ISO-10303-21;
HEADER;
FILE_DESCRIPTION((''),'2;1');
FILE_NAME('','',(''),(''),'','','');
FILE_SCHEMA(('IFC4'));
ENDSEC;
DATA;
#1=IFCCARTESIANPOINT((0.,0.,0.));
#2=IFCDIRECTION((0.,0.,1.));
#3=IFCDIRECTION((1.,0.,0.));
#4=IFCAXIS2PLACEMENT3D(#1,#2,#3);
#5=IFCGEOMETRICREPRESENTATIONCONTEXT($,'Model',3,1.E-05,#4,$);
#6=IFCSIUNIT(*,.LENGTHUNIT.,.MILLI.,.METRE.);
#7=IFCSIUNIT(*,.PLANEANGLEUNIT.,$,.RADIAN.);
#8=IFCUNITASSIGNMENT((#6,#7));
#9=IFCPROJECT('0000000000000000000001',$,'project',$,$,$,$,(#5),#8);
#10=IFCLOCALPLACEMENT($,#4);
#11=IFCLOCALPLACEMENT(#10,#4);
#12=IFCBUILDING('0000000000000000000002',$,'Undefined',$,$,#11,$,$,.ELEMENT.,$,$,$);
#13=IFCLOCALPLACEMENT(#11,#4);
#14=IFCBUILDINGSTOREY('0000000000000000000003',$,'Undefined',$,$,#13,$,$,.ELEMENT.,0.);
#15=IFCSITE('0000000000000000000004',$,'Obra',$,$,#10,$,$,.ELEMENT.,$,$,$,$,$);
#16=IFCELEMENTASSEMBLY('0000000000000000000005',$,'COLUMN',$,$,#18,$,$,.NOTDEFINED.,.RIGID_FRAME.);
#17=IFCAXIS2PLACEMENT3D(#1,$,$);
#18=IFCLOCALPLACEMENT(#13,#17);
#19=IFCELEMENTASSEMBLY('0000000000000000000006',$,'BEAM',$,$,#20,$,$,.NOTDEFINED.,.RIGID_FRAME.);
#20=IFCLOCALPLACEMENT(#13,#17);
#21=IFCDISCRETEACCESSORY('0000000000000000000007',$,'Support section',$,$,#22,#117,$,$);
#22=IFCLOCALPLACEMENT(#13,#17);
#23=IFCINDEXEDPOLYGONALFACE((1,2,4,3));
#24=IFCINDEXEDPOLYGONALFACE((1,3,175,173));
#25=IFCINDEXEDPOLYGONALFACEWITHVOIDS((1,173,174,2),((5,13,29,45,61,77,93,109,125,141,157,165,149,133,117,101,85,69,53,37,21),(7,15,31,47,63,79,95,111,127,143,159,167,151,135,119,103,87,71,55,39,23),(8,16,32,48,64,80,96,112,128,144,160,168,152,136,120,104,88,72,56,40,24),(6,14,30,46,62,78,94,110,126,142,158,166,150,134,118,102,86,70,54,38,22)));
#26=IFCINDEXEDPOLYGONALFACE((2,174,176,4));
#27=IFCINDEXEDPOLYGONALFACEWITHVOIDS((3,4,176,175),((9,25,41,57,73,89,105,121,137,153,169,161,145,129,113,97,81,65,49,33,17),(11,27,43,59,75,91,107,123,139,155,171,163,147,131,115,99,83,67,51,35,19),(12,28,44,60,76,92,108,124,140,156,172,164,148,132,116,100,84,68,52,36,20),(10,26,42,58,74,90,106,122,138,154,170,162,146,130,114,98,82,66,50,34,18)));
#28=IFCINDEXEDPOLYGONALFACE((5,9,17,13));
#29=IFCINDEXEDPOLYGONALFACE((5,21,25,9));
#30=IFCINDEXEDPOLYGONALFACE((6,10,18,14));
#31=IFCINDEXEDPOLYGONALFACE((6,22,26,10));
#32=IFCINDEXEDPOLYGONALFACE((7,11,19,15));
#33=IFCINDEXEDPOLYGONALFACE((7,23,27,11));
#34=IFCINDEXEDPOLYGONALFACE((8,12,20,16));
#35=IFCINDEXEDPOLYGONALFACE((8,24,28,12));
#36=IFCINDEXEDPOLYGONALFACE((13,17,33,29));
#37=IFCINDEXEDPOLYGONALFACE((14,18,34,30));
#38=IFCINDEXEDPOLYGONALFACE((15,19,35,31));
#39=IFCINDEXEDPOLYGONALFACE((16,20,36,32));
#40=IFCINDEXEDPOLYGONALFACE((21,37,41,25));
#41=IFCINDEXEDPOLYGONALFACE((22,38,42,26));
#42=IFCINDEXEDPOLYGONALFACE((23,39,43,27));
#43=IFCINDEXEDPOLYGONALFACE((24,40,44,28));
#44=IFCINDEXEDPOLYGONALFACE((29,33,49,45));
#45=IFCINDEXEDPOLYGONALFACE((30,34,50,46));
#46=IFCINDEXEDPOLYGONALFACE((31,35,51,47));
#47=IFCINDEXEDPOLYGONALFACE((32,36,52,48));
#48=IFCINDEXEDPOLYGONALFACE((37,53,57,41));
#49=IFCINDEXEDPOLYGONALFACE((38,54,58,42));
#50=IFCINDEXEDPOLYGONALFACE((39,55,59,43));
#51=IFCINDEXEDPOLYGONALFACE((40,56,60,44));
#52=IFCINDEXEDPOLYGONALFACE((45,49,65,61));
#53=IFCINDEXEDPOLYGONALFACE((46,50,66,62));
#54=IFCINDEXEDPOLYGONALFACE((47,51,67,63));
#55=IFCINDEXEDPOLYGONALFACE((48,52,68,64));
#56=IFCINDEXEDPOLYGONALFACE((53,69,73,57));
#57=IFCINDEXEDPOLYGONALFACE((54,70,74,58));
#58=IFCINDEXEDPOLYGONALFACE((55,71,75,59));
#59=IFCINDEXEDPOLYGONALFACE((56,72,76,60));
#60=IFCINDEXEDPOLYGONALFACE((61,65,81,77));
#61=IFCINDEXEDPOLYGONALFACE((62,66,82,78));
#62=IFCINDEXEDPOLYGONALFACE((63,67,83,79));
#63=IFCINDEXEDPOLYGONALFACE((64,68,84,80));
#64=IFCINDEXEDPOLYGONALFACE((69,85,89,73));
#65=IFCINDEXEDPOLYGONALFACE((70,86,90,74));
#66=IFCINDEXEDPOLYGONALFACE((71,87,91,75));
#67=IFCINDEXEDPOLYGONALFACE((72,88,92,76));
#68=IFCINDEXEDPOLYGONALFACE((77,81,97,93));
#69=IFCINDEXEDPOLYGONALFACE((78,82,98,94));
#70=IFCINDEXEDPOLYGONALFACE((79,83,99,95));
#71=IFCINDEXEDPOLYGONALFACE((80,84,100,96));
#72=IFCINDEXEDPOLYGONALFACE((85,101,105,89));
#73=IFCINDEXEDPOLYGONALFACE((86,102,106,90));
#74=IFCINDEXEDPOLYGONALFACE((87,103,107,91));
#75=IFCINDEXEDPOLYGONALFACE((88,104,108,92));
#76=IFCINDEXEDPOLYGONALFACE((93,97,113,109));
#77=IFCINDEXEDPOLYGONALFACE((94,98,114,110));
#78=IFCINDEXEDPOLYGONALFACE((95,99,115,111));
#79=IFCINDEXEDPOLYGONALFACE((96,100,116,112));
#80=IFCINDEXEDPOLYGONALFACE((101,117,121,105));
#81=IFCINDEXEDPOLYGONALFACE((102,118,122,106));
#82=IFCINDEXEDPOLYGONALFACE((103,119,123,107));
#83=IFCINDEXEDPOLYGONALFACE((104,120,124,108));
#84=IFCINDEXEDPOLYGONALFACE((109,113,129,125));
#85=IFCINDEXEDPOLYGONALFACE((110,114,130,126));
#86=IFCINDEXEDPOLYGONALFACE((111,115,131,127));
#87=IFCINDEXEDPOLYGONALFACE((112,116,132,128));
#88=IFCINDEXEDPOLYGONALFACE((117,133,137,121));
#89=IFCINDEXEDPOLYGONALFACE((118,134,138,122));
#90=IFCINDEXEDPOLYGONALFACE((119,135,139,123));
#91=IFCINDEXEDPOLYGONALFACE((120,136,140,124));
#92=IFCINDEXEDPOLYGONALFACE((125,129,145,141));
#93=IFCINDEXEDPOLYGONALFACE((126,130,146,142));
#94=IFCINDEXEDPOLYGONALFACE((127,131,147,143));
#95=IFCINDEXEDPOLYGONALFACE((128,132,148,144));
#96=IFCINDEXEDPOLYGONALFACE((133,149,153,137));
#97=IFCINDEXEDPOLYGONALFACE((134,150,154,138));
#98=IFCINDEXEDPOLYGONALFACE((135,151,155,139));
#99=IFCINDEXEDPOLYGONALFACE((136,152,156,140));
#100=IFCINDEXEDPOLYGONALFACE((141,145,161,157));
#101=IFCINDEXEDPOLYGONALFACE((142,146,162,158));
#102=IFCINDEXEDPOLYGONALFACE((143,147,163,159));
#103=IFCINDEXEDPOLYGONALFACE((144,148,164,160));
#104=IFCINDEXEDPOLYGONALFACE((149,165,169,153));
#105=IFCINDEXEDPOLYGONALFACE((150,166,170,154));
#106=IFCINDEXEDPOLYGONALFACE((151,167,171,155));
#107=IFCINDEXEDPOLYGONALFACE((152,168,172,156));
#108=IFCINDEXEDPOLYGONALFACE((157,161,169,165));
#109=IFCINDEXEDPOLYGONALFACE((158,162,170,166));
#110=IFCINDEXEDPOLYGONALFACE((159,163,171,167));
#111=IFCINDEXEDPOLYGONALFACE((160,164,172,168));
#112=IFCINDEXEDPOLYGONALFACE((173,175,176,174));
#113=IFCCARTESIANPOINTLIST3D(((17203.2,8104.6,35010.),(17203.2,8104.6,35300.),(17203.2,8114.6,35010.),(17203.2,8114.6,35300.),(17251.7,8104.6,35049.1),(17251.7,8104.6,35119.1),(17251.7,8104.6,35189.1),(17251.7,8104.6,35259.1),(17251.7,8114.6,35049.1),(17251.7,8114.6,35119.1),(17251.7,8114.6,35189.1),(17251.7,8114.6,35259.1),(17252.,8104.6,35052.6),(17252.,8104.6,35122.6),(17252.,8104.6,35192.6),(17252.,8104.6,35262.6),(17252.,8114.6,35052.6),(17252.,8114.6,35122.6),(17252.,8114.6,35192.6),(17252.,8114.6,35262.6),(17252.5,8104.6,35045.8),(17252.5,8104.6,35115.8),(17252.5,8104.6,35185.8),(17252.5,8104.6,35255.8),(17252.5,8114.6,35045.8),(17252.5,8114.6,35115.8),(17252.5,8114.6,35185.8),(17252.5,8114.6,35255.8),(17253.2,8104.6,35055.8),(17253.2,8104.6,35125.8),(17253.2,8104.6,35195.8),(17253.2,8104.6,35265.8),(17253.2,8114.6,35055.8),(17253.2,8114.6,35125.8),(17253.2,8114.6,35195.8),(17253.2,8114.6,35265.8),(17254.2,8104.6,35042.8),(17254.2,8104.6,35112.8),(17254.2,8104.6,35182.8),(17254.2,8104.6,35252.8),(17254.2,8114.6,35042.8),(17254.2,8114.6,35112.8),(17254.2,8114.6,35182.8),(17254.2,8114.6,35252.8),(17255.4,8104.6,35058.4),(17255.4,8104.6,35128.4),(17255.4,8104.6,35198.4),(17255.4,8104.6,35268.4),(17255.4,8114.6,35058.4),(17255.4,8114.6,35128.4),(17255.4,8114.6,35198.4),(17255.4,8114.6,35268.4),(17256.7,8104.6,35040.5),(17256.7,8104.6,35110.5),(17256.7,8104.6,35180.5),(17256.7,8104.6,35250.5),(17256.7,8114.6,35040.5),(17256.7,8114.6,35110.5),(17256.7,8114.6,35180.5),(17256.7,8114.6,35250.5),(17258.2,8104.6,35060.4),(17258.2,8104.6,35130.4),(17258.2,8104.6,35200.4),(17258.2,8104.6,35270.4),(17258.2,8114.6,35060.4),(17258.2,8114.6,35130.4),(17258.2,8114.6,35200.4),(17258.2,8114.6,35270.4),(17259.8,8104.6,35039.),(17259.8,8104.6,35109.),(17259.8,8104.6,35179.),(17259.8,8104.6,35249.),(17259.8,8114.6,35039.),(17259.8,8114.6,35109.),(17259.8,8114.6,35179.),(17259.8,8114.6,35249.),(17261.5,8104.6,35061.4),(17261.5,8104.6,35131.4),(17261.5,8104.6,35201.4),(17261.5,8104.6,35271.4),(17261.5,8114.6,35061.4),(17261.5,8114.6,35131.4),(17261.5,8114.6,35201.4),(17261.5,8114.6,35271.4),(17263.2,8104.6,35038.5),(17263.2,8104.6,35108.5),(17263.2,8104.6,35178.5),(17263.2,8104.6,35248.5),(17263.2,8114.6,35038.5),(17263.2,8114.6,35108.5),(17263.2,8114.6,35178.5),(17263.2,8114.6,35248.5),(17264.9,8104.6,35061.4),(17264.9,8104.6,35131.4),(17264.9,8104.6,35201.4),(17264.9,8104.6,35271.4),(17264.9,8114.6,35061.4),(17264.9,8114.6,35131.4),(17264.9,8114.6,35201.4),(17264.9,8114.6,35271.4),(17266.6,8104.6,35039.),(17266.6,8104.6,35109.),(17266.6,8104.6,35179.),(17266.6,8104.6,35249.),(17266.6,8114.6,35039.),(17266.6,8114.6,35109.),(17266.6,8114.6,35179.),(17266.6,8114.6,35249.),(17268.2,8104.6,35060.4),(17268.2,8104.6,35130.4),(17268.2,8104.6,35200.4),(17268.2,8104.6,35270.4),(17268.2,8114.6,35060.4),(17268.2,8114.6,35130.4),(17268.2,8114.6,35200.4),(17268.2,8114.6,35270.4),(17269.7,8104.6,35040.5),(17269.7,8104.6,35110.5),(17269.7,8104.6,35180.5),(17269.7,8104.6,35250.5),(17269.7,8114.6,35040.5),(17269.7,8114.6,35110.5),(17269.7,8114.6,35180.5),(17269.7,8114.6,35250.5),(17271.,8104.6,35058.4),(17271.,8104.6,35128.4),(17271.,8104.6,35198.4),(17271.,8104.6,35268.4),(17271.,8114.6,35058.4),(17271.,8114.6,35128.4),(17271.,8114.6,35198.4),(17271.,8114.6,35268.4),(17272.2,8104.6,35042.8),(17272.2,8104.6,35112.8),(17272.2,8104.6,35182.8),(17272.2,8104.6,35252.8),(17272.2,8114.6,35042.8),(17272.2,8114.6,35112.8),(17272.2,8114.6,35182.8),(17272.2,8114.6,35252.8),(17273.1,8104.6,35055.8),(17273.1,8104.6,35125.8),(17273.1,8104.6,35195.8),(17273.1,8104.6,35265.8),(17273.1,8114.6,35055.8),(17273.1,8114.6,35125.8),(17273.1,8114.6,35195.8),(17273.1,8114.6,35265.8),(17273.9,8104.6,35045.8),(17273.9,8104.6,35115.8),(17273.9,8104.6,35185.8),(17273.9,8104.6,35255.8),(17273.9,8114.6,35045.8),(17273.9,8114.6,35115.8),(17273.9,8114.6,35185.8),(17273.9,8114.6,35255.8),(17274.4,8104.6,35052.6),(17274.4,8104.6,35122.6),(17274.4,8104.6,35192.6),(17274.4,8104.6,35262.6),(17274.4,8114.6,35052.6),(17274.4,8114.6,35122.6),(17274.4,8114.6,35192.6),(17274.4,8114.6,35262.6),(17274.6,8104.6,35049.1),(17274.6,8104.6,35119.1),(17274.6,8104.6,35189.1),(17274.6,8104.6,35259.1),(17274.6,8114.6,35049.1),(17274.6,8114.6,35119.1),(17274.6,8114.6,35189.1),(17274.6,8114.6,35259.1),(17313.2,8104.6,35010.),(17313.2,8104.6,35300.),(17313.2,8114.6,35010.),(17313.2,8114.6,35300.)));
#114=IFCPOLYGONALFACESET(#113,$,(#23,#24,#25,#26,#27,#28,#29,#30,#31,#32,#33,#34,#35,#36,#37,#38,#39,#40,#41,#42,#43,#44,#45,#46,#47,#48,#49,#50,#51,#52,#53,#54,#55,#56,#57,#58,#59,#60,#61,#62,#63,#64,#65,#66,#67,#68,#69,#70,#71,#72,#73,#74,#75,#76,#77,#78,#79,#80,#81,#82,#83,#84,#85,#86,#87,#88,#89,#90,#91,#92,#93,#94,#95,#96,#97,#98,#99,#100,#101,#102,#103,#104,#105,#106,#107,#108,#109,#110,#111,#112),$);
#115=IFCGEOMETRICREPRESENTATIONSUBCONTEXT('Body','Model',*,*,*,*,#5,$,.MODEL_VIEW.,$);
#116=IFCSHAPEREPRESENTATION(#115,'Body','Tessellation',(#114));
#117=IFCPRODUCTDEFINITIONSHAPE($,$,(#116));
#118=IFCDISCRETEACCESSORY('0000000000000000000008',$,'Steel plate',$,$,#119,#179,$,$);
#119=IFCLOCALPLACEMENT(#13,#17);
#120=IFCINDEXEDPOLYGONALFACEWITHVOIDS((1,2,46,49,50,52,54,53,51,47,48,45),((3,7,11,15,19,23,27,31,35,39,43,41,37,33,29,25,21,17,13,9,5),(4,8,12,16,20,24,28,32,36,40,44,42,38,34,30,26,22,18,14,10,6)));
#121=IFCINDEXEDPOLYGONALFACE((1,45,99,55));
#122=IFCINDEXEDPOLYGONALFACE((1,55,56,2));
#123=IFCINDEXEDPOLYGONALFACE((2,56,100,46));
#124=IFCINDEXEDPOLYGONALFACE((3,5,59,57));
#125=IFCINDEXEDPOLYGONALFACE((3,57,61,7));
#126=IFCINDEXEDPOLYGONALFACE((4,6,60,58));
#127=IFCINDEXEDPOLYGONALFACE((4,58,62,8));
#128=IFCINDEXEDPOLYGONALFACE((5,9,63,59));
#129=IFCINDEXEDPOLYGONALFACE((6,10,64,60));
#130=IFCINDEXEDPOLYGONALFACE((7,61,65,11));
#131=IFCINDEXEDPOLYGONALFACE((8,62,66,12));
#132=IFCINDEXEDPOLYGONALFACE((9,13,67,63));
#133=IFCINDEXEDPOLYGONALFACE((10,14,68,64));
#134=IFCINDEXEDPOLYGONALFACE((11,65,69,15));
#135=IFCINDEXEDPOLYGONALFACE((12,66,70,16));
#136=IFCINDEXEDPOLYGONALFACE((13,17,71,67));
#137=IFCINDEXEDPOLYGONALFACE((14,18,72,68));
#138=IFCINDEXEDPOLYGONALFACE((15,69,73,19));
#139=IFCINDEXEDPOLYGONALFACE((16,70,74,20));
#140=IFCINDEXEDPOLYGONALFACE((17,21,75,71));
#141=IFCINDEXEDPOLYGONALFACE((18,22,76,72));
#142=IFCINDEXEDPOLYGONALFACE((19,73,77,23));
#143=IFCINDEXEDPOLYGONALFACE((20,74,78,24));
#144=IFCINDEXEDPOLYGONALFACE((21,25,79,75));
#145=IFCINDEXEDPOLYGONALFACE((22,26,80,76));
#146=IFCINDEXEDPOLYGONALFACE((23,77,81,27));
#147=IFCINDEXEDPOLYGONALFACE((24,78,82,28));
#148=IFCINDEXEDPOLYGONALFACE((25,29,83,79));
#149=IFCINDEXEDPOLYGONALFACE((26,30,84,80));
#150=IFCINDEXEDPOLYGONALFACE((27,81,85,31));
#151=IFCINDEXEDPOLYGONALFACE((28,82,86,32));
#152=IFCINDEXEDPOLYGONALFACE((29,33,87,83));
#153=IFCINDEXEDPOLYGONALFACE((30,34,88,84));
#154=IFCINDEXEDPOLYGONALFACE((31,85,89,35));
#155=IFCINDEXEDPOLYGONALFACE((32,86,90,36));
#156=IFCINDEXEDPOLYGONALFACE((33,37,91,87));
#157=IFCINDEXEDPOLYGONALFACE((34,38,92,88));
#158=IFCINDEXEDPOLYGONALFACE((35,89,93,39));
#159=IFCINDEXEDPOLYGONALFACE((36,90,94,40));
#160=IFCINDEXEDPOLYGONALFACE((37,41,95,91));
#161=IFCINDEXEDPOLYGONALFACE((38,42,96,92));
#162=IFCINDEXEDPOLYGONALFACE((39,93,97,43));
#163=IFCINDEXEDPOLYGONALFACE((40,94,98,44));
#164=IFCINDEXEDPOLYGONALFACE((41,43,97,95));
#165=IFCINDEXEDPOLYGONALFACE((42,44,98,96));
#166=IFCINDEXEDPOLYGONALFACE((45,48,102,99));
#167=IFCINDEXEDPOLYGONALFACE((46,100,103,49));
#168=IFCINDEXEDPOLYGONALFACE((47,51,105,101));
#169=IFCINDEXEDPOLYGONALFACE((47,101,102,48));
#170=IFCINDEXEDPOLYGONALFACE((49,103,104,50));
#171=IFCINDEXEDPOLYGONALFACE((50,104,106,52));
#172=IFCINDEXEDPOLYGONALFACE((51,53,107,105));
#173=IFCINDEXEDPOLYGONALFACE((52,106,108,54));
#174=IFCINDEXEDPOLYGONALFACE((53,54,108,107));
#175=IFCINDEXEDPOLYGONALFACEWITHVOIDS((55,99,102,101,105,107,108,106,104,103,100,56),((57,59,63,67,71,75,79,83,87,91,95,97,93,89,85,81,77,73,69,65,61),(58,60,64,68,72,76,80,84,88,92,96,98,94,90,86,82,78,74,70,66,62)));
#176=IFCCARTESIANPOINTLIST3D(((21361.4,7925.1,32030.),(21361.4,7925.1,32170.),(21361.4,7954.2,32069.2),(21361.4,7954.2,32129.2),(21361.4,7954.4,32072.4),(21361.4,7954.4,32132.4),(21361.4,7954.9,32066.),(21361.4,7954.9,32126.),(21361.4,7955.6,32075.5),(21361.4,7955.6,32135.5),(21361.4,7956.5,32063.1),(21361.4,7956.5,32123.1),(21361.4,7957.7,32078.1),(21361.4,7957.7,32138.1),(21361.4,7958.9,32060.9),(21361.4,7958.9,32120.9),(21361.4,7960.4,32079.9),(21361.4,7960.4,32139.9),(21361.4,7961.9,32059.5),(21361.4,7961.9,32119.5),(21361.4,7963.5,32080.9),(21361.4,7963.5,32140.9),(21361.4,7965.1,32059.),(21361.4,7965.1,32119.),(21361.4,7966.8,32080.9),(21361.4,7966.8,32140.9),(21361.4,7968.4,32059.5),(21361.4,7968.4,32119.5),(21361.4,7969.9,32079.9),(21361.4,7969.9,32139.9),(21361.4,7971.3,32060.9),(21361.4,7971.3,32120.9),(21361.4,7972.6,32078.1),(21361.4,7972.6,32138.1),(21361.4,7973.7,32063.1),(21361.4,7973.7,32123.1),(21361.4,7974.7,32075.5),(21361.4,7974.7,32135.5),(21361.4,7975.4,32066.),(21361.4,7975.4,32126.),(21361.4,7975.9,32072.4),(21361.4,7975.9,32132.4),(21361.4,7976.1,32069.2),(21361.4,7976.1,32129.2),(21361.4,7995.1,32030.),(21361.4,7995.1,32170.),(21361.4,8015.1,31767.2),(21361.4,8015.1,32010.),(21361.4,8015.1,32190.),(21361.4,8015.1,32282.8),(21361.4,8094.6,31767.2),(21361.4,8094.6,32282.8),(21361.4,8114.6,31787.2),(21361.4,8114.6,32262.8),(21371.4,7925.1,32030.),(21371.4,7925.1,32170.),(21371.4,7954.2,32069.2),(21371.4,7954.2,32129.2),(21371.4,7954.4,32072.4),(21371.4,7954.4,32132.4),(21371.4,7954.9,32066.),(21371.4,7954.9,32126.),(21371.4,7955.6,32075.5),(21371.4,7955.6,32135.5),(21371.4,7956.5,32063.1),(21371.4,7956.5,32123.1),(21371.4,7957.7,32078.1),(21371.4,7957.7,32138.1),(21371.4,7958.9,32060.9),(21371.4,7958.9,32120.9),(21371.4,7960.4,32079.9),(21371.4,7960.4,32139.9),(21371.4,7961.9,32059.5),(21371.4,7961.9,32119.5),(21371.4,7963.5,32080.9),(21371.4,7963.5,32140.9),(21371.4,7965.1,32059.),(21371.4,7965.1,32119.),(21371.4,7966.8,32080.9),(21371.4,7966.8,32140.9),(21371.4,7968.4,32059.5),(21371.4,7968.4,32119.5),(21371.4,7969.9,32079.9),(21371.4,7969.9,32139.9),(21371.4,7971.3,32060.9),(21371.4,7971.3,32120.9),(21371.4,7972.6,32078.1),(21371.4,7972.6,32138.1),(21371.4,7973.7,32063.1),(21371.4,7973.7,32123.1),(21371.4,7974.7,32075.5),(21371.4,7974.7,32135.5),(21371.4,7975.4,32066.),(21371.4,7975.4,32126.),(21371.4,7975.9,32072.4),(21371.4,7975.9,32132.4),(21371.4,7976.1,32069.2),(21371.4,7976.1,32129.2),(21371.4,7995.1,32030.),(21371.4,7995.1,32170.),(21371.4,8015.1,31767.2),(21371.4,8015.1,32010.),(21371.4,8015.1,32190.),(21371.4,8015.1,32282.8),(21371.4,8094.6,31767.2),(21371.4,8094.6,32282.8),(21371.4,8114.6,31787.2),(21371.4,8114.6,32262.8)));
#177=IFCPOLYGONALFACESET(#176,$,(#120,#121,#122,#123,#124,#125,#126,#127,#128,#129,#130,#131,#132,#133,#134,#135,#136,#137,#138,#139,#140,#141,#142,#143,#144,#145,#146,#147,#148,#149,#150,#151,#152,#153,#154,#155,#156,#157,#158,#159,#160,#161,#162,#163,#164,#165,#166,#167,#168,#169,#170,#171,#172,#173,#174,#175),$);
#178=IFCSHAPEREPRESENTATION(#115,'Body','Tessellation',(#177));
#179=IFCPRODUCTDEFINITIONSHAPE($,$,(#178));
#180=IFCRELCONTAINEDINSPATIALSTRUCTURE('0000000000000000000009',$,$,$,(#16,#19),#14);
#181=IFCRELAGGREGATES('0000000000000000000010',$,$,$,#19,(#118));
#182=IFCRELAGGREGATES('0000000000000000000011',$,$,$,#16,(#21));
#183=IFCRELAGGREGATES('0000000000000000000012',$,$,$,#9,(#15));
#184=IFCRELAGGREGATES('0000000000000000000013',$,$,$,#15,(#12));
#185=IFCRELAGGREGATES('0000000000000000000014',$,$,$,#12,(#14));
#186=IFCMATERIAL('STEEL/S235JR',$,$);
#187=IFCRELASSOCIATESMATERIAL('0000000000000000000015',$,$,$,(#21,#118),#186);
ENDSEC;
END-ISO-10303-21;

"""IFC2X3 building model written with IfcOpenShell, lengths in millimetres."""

from ifc_helpers import new_model, si_unit, frame, origin_with_axes, origin_2d_with_axis, place, context, subcontext, project, spatial, polyline, rectangle, circle, outline, extrude, source, transform, mapped, material, element, aggregate, save


model = new_model("IFC2X3")

# Units and contexts
model_context = context("Model", 3, precision=1e-05, world=origin_with_axes())
body_context = subcontext(model_context, "Body", "Model", "MODEL_VIEW")
ifc_project = project(units=[si_unit("LENGTHUNIT", "METRE", prefix="MILLI"), si_unit("PLANEANGLEUNIT", "RADIAN")], contexts=[model_context])

# Site, building, storey
site_placement = place(None, origin_with_axes())
site = spatial("IfcSite", under=ifc_project, at=site_placement, Name="Obra", CompositionType="ELEMENT")
building_placement = place(site_placement, origin_with_axes())
building = spatial("IfcBuilding", under=site, at=building_placement, Name="Undefined", CompositionType="ELEMENT")
storey_placement = place(building_placement, origin_with_axes())
storey = spatial("IfcBuildingStorey", under=building, at=storey_placement, Name="Undefined", CompositionType="ELEMENT", Elevation=0.0)

# Element assembly
assembly_1_placement = place(storey_placement, origin_with_axes())
assembly_1 = element("IfcElementAssembly", 1, at=assembly_1_placement, inside=storey, Name="COLUMN", AssemblyPlace="NOTDEFINED", PredefinedType="RIGID_FRAME")
ifc_material_1 = material(Name="STEEL/S235JR")

# Element assembly
assembly_2_placement = place(storey_placement, origin_with_axes())
assembly_2 = element("IfcElementAssembly", 2, at=assembly_2_placement, inside=storey, Name="BEAM", AssemblyPlace="NOTDEFINED", PredefinedType="RIGID_FRAME")

# Discrete accessories, openings
discrete_accessory_1_placement = place(assembly_1_placement, frame((17258.2, 8109.6, 35010.0), z_axis=(0.0, 0.0, 1.0), x_axis=(-1.0, 0.0, 0.0)))
discrete_accessory_1 = element("IfcDiscreteAccessory", 3, at=discrete_accessory_1_placement, material=ifc_material_1, Name="Support section", context=body_context, shape_type="SweptSolid", body=[
    extrude(rectangle(XDim=10.0, YDim=110.0, at=origin_2d_with_axis()), frame((0.0, 0.0, 290.0), z_axis=(0.0, 0.0, -1.0), x_axis=(0.0, 1.0, 0.0)), (0.0, 0.0, 1.0), 290.0),
])
shared_shape_1 = source(origin_with_axes(), body_context, "Body", "SweptSolid", [
    extrude(circle(Radius=11.5, at=origin_2d_with_axis()), frame((0.0, -15.6, 0.0), z_axis=(0.0, 1.0, 0.0), x_axis=(1.0, 0.0, 0.0)), (0.0, 0.0, 1.0), 10.2),
])
opening_1_placement = place(assembly_1_placement, frame((17213.2, 8120.1, 35350.0), z_axis=(1.0, 0.0, 0.0), x_axis=(0.0, 0.0, -1.0)))
element("IfcOpeningElement", 4, at=opening_1_placement, cuts=discrete_accessory_1, ObjectType="Opening", context=body_context, shape_type="MappedRepresentation", body=[
    mapped(shared_shape_1, transform((90.0, 0.0, 50.0))),
    mapped(shared_shape_1, transform((160.0, 0.0, 50.0))),
    mapped(shared_shape_1, transform((230.0, 0.0, 50.0))),
    mapped(shared_shape_1, transform((300.0, 0.0, 50.0))),
])
discrete_accessory_2_placement = place(assembly_2_placement, frame((21366.4, 8114.6, 31787.2), z_axis=(-1.0, 0.0, 0.0), x_axis=(0.0, -0.707107, -0.707107)))
discrete_accessory_2 = element("IfcDiscreteAccessory", 5, at=discrete_accessory_2_placement, material=ifc_material_1, Name="Steel plate", context=body_context, shape_type="SweptSolid", body=[
    extrude(outline(polyline([(0.0, 0.0), (28.3, 0.0), (84.5, 56.2), (-87.2, 227.9), (-87.2, 256.1), (-37.7, 305.6), (-136.7, 404.6), (-186.2, 355.1), (-214.5, 355.1), (-280.1, 420.8), (-336.3, 364.6), (-336.3, 336.3), (0.0, 0.0)])), frame((0.0, 0.0, -5.0), z_axis=(0.0, 0.0, 1.0), x_axis=(1.0, 0.0, 0.0)), (0.0, 0.0, 1.0), 10.0),
])
shared_shape_2 = source(origin_with_axes(), body_context, "Body", "SweptSolid", [
    extrude(circle(Radius=11.0, at=origin_2d_with_axis()), frame((0.0, -14.4, 0.0), z_axis=(0.0, 1.0, 0.0), x_axis=(1.0, 0.0, 0.0)), (0.0, 0.0, 1.0), 10.2),
])
opening_2_placement = place(assembly_2_placement, frame((21375.7, 8005.1, 32170.0), z_axis=(0.0, -1.0, 0.0), x_axis=(0.0, 0.0, -1.0)))
element("IfcOpeningElement", 6, at=opening_2_placement, cuts=discrete_accessory_2, ObjectType="Opening", context=body_context, shape_type="MappedRepresentation", body=[
    mapped(shared_shape_2, transform((40.0, 0.0, 40.0))),
    mapped(shared_shape_2, transform((100.0, 0.0, 40.0))),
])
aggregate(assembly_2, [discrete_accessory_2])
aggregate(assembly_1, [discrete_accessory_1])

save(model, "model.ifc")
